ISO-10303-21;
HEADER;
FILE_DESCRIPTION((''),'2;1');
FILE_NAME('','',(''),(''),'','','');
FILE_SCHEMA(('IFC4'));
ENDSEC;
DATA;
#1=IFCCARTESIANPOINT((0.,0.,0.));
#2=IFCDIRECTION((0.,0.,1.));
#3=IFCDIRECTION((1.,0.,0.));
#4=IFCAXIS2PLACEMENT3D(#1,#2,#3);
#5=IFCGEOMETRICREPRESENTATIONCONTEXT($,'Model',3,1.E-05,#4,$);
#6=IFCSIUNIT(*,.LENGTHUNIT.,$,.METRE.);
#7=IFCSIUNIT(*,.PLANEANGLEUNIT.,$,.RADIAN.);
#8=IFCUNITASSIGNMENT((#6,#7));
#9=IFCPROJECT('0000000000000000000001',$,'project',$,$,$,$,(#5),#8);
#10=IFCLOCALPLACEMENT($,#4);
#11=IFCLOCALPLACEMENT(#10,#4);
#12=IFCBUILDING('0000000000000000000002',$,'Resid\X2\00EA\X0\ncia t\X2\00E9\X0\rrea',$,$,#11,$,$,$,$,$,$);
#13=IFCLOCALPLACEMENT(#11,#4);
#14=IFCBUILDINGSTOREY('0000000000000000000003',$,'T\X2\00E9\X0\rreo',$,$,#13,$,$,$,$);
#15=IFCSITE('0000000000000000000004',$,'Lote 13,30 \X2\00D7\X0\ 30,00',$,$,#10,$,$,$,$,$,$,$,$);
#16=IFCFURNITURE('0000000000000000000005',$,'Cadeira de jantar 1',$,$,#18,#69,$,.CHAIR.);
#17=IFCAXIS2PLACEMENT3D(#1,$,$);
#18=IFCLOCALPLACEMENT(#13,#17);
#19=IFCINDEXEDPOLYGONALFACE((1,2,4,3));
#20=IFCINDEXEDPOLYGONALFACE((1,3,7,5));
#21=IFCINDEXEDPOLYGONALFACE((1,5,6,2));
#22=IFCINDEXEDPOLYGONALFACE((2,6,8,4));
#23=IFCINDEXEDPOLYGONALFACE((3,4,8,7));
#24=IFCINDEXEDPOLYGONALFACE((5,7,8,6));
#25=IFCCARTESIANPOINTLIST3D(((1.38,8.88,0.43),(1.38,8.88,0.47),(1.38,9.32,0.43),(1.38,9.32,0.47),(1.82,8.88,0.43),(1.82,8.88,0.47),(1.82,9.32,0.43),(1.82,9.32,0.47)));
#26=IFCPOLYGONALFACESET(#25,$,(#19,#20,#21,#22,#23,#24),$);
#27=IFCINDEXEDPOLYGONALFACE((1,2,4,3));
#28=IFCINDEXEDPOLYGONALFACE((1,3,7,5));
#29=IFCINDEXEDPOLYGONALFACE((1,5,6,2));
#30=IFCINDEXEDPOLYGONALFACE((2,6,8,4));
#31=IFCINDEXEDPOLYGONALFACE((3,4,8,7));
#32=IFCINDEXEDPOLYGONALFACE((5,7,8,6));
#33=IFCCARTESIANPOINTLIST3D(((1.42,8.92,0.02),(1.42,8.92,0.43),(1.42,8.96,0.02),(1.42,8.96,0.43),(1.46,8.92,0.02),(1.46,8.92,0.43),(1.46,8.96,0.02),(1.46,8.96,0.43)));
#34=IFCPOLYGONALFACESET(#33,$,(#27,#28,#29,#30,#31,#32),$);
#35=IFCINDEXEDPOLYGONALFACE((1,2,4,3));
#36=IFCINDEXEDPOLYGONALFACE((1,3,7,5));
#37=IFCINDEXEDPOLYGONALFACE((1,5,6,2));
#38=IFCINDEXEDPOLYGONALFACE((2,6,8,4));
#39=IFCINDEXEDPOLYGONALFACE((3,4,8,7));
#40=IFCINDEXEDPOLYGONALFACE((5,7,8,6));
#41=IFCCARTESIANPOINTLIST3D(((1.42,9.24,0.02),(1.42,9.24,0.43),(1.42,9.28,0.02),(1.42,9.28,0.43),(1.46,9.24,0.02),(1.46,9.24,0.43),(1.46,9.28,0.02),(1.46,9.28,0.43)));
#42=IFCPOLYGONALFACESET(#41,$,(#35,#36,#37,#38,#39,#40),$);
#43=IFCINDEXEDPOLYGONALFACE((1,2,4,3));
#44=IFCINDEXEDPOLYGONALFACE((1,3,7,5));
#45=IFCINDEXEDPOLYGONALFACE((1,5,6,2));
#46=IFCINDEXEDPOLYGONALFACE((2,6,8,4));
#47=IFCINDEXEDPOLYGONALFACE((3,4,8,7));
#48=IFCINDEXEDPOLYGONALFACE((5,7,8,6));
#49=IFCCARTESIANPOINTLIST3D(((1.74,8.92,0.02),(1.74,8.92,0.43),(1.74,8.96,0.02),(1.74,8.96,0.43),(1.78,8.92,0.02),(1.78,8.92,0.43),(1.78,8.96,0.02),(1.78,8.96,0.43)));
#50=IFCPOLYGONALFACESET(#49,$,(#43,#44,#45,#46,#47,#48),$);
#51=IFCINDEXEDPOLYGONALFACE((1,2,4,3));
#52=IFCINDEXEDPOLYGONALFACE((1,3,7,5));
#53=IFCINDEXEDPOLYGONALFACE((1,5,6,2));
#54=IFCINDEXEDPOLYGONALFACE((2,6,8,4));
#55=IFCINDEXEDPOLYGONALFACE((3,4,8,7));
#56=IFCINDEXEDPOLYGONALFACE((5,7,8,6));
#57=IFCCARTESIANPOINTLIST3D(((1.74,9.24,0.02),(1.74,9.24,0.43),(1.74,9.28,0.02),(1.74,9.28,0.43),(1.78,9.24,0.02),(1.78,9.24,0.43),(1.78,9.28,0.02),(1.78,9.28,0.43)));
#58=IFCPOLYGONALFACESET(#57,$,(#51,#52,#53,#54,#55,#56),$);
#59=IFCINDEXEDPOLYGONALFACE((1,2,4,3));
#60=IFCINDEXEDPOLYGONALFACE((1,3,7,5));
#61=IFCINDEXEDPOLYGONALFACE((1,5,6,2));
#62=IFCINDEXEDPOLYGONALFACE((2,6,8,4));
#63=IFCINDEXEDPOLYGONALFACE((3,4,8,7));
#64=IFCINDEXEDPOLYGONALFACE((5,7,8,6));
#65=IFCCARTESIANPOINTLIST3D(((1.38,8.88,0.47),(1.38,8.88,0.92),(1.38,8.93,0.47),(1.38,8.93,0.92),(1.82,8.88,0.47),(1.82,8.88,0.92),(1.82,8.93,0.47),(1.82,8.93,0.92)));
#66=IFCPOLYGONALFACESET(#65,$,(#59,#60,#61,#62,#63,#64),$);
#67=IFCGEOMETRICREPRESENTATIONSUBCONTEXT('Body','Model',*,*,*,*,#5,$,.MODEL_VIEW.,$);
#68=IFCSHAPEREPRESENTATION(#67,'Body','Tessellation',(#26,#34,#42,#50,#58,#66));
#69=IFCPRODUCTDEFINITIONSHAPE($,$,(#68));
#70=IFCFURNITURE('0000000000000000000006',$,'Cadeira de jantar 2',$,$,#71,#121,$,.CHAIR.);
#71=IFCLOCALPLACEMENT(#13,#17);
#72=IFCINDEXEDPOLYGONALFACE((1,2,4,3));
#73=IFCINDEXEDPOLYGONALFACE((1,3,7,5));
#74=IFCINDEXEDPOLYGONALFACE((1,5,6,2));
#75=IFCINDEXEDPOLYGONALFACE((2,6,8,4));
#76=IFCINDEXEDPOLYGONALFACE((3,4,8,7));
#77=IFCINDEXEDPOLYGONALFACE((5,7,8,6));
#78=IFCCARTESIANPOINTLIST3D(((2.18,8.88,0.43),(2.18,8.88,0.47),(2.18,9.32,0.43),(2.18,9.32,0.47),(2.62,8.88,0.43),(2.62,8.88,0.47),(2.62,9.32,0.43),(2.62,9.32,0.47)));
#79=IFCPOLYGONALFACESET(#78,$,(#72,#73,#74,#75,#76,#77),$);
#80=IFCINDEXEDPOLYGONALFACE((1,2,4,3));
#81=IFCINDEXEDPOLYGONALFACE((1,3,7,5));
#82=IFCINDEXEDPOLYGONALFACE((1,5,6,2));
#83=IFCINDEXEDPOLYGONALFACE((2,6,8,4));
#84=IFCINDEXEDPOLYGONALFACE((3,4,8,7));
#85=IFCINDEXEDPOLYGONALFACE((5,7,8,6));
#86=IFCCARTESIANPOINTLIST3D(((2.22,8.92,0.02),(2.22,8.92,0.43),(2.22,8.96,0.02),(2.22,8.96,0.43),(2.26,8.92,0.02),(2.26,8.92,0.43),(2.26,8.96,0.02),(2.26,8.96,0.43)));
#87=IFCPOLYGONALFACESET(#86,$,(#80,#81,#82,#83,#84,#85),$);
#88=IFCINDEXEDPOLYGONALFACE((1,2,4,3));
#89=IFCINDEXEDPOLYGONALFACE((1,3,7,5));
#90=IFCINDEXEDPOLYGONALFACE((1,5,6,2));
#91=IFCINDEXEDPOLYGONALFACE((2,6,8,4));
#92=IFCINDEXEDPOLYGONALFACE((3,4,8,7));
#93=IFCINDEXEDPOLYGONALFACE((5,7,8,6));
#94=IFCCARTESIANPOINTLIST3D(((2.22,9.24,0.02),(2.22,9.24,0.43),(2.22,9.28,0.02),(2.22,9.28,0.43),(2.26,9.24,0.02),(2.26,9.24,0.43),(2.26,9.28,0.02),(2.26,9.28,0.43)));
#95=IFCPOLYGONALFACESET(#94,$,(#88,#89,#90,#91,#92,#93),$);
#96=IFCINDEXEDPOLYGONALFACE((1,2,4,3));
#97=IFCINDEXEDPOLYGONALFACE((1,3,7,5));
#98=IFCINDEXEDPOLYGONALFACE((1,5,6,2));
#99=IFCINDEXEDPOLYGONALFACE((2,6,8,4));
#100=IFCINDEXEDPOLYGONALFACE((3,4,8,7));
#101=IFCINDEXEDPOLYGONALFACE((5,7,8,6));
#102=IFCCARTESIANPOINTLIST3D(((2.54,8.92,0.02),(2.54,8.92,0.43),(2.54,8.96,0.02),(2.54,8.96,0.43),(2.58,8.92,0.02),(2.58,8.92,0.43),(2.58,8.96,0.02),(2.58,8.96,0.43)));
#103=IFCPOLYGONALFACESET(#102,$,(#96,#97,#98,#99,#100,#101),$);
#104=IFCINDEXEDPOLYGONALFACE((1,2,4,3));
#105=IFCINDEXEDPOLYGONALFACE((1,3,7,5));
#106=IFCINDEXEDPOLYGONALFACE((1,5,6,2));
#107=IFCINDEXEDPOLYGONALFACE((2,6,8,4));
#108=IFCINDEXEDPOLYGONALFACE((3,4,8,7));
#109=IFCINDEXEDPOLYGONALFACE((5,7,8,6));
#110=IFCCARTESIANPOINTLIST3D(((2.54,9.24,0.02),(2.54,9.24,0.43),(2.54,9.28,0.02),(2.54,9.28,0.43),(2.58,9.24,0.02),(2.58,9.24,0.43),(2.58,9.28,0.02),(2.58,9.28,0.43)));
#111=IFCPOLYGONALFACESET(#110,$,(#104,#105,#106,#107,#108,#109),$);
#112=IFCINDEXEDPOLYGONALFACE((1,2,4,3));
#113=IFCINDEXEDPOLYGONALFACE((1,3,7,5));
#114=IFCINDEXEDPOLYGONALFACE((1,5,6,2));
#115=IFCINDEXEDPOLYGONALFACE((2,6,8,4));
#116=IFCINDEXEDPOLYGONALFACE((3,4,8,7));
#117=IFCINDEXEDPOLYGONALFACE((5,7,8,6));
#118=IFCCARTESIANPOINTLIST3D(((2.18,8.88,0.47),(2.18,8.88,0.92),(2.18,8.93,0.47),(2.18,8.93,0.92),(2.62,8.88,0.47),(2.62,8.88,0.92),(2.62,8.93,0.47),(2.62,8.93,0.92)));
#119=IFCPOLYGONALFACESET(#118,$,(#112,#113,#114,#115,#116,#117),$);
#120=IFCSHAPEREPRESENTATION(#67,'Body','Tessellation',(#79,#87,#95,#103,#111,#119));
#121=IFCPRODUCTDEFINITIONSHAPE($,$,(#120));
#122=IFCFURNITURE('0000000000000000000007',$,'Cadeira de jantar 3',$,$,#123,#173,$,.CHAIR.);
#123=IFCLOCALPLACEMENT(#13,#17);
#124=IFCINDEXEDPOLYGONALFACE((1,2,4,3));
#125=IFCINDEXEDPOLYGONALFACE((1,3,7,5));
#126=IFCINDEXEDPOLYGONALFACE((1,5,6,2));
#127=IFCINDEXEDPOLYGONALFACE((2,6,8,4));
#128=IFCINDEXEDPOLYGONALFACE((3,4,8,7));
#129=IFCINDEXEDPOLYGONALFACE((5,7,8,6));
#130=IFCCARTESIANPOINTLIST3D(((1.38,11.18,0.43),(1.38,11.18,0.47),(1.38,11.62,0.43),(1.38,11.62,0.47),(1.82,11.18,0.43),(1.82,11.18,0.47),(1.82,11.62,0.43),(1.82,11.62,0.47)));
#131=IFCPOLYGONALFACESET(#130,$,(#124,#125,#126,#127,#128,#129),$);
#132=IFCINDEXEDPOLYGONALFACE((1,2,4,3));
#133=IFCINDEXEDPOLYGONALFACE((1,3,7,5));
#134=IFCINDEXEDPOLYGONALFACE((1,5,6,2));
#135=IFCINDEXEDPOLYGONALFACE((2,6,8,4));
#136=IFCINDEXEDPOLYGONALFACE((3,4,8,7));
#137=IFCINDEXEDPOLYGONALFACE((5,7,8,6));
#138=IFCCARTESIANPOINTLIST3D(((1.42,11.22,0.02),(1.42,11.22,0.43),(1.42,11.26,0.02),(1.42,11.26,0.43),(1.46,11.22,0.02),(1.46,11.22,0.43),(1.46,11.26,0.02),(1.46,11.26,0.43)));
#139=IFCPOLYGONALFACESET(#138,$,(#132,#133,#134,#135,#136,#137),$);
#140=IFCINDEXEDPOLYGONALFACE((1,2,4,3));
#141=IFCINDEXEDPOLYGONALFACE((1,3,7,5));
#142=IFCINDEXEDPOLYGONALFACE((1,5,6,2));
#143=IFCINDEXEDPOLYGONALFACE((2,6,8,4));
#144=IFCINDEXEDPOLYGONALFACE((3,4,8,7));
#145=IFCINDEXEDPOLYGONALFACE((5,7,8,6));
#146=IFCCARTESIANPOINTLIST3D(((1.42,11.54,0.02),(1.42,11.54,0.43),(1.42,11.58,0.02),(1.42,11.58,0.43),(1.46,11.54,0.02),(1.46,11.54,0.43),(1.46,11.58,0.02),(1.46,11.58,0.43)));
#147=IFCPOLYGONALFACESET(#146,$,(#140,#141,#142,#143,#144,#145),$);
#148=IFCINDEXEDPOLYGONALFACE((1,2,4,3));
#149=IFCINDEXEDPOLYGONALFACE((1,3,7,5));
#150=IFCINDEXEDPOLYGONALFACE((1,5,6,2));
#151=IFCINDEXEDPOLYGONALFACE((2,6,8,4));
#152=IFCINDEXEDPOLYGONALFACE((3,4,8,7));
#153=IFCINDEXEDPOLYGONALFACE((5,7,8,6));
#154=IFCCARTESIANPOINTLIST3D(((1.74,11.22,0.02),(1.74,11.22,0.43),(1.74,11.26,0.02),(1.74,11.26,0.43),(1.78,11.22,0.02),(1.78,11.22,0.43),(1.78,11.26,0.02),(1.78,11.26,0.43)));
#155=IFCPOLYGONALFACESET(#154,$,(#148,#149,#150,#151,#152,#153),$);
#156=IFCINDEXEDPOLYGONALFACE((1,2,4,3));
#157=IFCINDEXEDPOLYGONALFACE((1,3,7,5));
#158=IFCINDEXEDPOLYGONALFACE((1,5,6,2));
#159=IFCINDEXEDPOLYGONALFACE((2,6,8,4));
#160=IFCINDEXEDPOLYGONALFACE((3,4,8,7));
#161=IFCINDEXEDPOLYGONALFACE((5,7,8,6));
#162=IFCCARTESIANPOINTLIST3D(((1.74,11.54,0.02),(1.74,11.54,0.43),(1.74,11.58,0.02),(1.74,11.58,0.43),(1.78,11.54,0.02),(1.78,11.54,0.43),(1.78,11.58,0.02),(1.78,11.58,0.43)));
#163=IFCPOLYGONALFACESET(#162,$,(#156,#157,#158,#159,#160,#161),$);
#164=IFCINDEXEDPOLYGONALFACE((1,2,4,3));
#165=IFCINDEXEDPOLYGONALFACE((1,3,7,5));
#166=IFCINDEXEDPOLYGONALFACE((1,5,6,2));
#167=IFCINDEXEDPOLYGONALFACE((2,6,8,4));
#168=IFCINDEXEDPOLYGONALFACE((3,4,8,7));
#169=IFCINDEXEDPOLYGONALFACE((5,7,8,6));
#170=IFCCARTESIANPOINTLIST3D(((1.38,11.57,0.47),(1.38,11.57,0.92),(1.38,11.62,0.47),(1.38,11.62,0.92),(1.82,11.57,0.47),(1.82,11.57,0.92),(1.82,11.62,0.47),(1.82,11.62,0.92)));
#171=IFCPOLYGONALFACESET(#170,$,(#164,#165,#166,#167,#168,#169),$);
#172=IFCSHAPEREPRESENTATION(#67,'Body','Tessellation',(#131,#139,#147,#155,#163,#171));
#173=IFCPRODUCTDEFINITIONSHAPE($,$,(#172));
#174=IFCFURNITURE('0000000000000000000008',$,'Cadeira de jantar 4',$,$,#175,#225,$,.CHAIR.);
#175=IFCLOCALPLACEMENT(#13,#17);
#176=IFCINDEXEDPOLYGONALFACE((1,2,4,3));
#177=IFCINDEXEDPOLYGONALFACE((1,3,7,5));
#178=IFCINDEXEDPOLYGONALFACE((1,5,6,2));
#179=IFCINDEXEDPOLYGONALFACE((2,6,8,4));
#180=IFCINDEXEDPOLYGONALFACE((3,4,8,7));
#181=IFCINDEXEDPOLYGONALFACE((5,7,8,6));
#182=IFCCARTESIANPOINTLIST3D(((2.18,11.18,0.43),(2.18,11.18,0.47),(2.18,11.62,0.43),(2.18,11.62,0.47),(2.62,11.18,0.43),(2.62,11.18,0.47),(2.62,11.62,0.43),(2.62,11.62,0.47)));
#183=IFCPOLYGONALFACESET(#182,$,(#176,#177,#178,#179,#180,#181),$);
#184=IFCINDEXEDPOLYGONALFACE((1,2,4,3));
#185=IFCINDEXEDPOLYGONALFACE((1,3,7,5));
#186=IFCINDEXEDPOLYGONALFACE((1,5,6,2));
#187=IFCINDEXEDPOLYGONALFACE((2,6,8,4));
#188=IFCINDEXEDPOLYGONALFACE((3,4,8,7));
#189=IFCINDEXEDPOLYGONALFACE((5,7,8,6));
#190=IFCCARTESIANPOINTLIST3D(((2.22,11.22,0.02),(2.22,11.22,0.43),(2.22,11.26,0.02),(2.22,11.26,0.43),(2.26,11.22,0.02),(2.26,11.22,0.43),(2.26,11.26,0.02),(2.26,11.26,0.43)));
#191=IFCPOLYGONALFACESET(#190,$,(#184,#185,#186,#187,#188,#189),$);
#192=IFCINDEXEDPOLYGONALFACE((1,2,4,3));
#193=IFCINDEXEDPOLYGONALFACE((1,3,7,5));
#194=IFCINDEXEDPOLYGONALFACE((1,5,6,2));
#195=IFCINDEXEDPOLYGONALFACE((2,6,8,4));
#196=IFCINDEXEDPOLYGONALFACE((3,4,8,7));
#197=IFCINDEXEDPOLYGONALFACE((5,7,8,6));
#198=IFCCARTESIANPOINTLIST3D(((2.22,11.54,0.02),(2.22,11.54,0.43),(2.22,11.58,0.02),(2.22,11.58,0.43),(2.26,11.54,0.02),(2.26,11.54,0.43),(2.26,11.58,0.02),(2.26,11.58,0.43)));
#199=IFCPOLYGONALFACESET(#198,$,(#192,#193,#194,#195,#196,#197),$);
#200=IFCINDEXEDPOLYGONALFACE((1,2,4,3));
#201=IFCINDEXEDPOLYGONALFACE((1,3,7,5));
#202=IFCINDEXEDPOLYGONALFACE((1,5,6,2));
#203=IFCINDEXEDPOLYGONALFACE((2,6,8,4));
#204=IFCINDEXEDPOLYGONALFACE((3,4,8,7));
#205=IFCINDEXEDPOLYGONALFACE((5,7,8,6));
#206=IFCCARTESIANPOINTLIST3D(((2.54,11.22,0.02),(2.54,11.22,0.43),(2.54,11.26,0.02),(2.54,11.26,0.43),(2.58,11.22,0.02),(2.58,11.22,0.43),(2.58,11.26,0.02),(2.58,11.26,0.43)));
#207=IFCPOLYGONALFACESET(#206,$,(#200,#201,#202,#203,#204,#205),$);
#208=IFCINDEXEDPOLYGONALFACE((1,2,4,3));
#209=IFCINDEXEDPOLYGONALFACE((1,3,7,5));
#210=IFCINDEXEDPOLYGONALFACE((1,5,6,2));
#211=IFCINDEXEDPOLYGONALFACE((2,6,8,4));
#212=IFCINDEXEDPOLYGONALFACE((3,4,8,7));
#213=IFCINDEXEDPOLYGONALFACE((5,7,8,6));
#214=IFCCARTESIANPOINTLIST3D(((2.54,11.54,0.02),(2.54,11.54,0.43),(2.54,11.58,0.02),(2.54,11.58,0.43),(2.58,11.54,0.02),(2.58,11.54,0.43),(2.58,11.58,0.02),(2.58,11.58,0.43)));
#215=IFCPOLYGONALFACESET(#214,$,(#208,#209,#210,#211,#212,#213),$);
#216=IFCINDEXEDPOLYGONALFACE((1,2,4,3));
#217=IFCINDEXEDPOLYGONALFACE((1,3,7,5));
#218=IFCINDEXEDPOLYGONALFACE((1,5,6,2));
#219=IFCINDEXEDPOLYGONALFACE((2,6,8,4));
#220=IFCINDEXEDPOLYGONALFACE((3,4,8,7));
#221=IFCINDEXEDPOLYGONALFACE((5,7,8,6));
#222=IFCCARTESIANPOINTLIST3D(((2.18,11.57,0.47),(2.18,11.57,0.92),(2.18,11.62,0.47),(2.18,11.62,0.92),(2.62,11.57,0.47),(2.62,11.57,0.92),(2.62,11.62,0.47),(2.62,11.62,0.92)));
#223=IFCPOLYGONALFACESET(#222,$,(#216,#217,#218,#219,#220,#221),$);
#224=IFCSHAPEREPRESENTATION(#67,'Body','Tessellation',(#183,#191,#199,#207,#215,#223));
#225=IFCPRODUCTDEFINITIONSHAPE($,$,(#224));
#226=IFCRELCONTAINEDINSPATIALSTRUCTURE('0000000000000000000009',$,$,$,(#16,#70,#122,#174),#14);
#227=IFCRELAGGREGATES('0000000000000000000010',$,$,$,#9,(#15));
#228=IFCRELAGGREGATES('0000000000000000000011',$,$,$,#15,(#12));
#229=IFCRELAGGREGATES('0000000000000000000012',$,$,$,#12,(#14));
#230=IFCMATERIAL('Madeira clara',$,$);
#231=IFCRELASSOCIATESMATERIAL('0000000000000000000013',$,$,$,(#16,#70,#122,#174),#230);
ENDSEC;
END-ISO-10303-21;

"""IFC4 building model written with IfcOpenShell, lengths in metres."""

from ifc_helpers import new_model, si_unit, frame, origin_with_axes, place, context, subcontext, project, spatial, line, indexed_curve, outline, extrude, material, element, save


model = new_model("IFC4")

# Units and contexts
model_context = context("Model", 3, precision=1e-05, world=origin_with_axes())
body_context = subcontext(model_context, "Body", "Model", "MODEL_VIEW")
ifc_project = project(units=[si_unit("LENGTHUNIT", "METRE"), si_unit("PLANEANGLEUNIT", "RADIAN")], contexts=[model_context])

# Site, building, storey
site_placement = place(None, origin_with_axes())
site = spatial("IfcSite", under=ifc_project, at=site_placement, Name="Lote 13,30 × 30,00")
building_placement = place(site_placement, origin_with_axes())
building = spatial("IfcBuilding", under=site, at=building_placement, Name="Residência térrea")
storey_placement = place(building_placement, origin_with_axes())
storey = spatial("IfcBuildingStorey", under=building, at=storey_placement, Name="Térreo")

# Furniture
ifc_material_1 = material(Name="Madeira clara")
furniture_1_placement = place(storey_placement, frame((1.38, 8.88, 0.02), z_axis=(0.0, 0.0, 1.0), x_axis=(1.0, 0.0, 0.0)))
element("IfcFurniture", 1, at=furniture_1_placement, inside=storey, material=ifc_material_1, Name="Cadeira de jantar 1", PredefinedType="CHAIR", context=body_context, shape_type="SweptSolid", body=[
    extrude(outline(indexed_curve([(0.0, 0.0), (0.44, 0.0), (0.44, 0.44), (0.0, 0.44)], segments=[line(1, 2, 3, 4, 1)])), frame((0.0, 0.0, 0.41), z_axis=(0.0, 0.0, 1.0), x_axis=(1.0, 0.0, 0.0)), (0.0, 0.0, 1.0), 0.04),
    extrude(outline(indexed_curve([(0.04, 0.04), (0.08, 0.04), (0.08, 0.08), (0.04, 0.08)], segments=[line(1, 2, 3, 4, 1)])), origin_with_axes(), (0.0, 0.0, 1.0), 0.41),
    extrude(outline(indexed_curve([(0.04, 0.36), (0.08, 0.36), (0.08, 0.4), (0.04, 0.4)], segments=[line(1, 2, 3, 4, 1)])), origin_with_axes(), (0.0, 0.0, 1.0), 0.41),
    extrude(outline(indexed_curve([(0.36, 0.04), (0.4, 0.04), (0.4, 0.08), (0.36, 0.08)], segments=[line(1, 2, 3, 4, 1)])), origin_with_axes(), (0.0, 0.0, 1.0), 0.41),
    extrude(outline(indexed_curve([(0.36, 0.36), (0.4, 0.36), (0.4, 0.4), (0.36, 0.4)], segments=[line(1, 2, 3, 4, 1)])), origin_with_axes(), (0.0, 0.0, 1.0), 0.41),
    extrude(outline(indexed_curve([(0.0, 0.0), (0.44, 0.0), (0.44, 0.05), (0.0, 0.05)], segments=[line(1, 2, 3, 4, 1)])), frame((0.0, 0.0, 0.45), z_axis=(0.0, 0.0, 1.0), x_axis=(1.0, 0.0, 0.0)), (0.0, 0.0, 1.0), 0.45),
])
furniture_2_placement = place(storey_placement, frame((2.18, 8.88, 0.02), z_axis=(0.0, 0.0, 1.0), x_axis=(1.0, 0.0, 0.0)))
element("IfcFurniture", 2, at=furniture_2_placement, inside=storey, material=ifc_material_1, Name="Cadeira de jantar 2", PredefinedType="CHAIR", context=body_context, shape_type="SweptSolid", body=[
    extrude(outline(indexed_curve([(0.0, 0.0), (0.44, 0.0), (0.44, 0.44), (0.0, 0.44)], segments=[line(1, 2, 3, 4, 1)])), frame((0.0, 0.0, 0.41), z_axis=(0.0, 0.0, 1.0), x_axis=(1.0, 0.0, 0.0)), (0.0, 0.0, 1.0), 0.04),
    extrude(outline(indexed_curve([(0.04, 0.04), (0.08, 0.04), (0.08, 0.08), (0.04, 0.08)], segments=[line(1, 2, 3, 4, 1)])), origin_with_axes(), (0.0, 0.0, 1.0), 0.41),
    extrude(outline(indexed_curve([(0.04, 0.36), (0.08, 0.36), (0.08, 0.4), (0.04, 0.4)], segments=[line(1, 2, 3, 4, 1)])), origin_with_axes(), (0.0, 0.0, 1.0), 0.41),
    extrude(outline(indexed_curve([(0.36, 0.04), (0.4, 0.04), (0.4, 0.08), (0.36, 0.08)], segments=[line(1, 2, 3, 4, 1)])), origin_with_axes(), (0.0, 0.0, 1.0), 0.41),
    extrude(outline(indexed_curve([(0.36, 0.36), (0.4, 0.36), (0.4, 0.4), (0.36, 0.4)], segments=[line(1, 2, 3, 4, 1)])), origin_with_axes(), (0.0, 0.0, 1.0), 0.41),
    extrude(outline(indexed_curve([(0.0, 0.0), (0.44, 0.0), (0.44, 0.05), (0.0, 0.05)], segments=[line(1, 2, 3, 4, 1)])), frame((0.0, 0.0, 0.45), z_axis=(0.0, 0.0, 1.0), x_axis=(1.0, 0.0, 0.0)), (0.0, 0.0, 1.0), 0.45),
])
furniture_3_placement = place(storey_placement, frame((1.38, 11.18, 0.02), z_axis=(0.0, 0.0, 1.0), x_axis=(1.0, 0.0, 0.0)))
element("IfcFurniture", 3, at=furniture_3_placement, inside=storey, material=ifc_material_1, Name="Cadeira de jantar 3", PredefinedType="CHAIR", context=body_context, shape_type="SweptSolid", body=[
    extrude(outline(indexed_curve([(0.0, 0.0), (0.44, 0.0), (0.44, 0.44), (0.0, 0.44)], segments=[line(1, 2, 3, 4, 1)])), frame((0.0, 0.0, 0.41), z_axis=(0.0, 0.0, 1.0), x_axis=(1.0, 0.0, 0.0)), (0.0, 0.0, 1.0), 0.04),
    extrude(outline(indexed_curve([(0.04, 0.04), (0.08, 0.04), (0.08, 0.08), (0.04, 0.08)], segments=[line(1, 2, 3, 4, 1)])), origin_with_axes(), (0.0, 0.0, 1.0), 0.41),
    extrude(outline(indexed_curve([(0.04, 0.36), (0.08, 0.36), (0.08, 0.4), (0.04, 0.4)], segments=[line(1, 2, 3, 4, 1)])), origin_with_axes(), (0.0, 0.0, 1.0), 0.41),
    extrude(outline(indexed_curve([(0.36, 0.04), (0.4, 0.04), (0.4, 0.08), (0.36, 0.08)], segments=[line(1, 2, 3, 4, 1)])), origin_with_axes(), (0.0, 0.0, 1.0), 0.41),
    extrude(outline(indexed_curve([(0.36, 0.36), (0.4, 0.36), (0.4, 0.4), (0.36, 0.4)], segments=[line(1, 2, 3, 4, 1)])), origin_with_axes(), (0.0, 0.0, 1.0), 0.41),
    extrude(outline(indexed_curve([(0.0, 0.39), (0.44, 0.39), (0.44, 0.44), (0.0, 0.44)], segments=[line(1, 2, 3, 4, 1)])), frame((0.0, 0.0, 0.45), z_axis=(0.0, 0.0, 1.0), x_axis=(1.0, 0.0, 0.0)), (0.0, 0.0, 1.0), 0.45),
])
furniture_4_placement = place(storey_placement, frame((2.18, 11.18, 0.02), z_axis=(0.0, 0.0, 1.0), x_axis=(1.0, 0.0, 0.0)))
element("IfcFurniture", 4, at=furniture_4_placement, inside=storey, material=ifc_material_1, Name="Cadeira de jantar 4", PredefinedType="CHAIR", context=body_context, shape_type="SweptSolid", body=[
    extrude(outline(indexed_curve([(0.0, 0.0), (0.44, 0.0), (0.44, 0.44), (0.0, 0.44)], segments=[line(1, 2, 3, 4, 1)])), frame((0.0, 0.0, 0.41), z_axis=(0.0, 0.0, 1.0), x_axis=(1.0, 0.0, 0.0)), (0.0, 0.0, 1.0), 0.04),
    extrude(outline(indexed_curve([(0.04, 0.04), (0.08, 0.04), (0.08, 0.08), (0.04, 0.08)], segments=[line(1, 2, 3, 4, 1)])), origin_with_axes(), (0.0, 0.0, 1.0), 0.41),
    extrude(outline(indexed_curve([(0.04, 0.36), (0.08, 0.36), (0.08, 0.4), (0.04, 0.4)], segments=[line(1, 2, 3, 4, 1)])), origin_with_axes(), (0.0, 0.0, 1.0), 0.41),
    extrude(outline(indexed_curve([(0.36, 0.04), (0.4, 0.04), (0.4, 0.08), (0.36, 0.08)], segments=[line(1, 2, 3, 4, 1)])), origin_with_axes(), (0.0, 0.0, 1.0), 0.41),
    extrude(outline(indexed_curve([(0.36, 0.36), (0.4, 0.36), (0.4, 0.4), (0.36, 0.4)], segments=[line(1, 2, 3, 4, 1)])), origin_with_axes(), (0.0, 0.0, 1.0), 0.41),
    extrude(outline(indexed_curve([(0.0, 0.39), (0.44, 0.39), (0.44, 0.44), (0.0, 0.44)], segments=[line(1, 2, 3, 4, 1)])), frame((0.0, 0.0, 0.45), z_axis=(0.0, 0.0, 1.0), x_axis=(1.0, 0.0, 0.0)), (0.0, 0.0, 1.0), 0.45),
])

save(model, "model.ifc")
